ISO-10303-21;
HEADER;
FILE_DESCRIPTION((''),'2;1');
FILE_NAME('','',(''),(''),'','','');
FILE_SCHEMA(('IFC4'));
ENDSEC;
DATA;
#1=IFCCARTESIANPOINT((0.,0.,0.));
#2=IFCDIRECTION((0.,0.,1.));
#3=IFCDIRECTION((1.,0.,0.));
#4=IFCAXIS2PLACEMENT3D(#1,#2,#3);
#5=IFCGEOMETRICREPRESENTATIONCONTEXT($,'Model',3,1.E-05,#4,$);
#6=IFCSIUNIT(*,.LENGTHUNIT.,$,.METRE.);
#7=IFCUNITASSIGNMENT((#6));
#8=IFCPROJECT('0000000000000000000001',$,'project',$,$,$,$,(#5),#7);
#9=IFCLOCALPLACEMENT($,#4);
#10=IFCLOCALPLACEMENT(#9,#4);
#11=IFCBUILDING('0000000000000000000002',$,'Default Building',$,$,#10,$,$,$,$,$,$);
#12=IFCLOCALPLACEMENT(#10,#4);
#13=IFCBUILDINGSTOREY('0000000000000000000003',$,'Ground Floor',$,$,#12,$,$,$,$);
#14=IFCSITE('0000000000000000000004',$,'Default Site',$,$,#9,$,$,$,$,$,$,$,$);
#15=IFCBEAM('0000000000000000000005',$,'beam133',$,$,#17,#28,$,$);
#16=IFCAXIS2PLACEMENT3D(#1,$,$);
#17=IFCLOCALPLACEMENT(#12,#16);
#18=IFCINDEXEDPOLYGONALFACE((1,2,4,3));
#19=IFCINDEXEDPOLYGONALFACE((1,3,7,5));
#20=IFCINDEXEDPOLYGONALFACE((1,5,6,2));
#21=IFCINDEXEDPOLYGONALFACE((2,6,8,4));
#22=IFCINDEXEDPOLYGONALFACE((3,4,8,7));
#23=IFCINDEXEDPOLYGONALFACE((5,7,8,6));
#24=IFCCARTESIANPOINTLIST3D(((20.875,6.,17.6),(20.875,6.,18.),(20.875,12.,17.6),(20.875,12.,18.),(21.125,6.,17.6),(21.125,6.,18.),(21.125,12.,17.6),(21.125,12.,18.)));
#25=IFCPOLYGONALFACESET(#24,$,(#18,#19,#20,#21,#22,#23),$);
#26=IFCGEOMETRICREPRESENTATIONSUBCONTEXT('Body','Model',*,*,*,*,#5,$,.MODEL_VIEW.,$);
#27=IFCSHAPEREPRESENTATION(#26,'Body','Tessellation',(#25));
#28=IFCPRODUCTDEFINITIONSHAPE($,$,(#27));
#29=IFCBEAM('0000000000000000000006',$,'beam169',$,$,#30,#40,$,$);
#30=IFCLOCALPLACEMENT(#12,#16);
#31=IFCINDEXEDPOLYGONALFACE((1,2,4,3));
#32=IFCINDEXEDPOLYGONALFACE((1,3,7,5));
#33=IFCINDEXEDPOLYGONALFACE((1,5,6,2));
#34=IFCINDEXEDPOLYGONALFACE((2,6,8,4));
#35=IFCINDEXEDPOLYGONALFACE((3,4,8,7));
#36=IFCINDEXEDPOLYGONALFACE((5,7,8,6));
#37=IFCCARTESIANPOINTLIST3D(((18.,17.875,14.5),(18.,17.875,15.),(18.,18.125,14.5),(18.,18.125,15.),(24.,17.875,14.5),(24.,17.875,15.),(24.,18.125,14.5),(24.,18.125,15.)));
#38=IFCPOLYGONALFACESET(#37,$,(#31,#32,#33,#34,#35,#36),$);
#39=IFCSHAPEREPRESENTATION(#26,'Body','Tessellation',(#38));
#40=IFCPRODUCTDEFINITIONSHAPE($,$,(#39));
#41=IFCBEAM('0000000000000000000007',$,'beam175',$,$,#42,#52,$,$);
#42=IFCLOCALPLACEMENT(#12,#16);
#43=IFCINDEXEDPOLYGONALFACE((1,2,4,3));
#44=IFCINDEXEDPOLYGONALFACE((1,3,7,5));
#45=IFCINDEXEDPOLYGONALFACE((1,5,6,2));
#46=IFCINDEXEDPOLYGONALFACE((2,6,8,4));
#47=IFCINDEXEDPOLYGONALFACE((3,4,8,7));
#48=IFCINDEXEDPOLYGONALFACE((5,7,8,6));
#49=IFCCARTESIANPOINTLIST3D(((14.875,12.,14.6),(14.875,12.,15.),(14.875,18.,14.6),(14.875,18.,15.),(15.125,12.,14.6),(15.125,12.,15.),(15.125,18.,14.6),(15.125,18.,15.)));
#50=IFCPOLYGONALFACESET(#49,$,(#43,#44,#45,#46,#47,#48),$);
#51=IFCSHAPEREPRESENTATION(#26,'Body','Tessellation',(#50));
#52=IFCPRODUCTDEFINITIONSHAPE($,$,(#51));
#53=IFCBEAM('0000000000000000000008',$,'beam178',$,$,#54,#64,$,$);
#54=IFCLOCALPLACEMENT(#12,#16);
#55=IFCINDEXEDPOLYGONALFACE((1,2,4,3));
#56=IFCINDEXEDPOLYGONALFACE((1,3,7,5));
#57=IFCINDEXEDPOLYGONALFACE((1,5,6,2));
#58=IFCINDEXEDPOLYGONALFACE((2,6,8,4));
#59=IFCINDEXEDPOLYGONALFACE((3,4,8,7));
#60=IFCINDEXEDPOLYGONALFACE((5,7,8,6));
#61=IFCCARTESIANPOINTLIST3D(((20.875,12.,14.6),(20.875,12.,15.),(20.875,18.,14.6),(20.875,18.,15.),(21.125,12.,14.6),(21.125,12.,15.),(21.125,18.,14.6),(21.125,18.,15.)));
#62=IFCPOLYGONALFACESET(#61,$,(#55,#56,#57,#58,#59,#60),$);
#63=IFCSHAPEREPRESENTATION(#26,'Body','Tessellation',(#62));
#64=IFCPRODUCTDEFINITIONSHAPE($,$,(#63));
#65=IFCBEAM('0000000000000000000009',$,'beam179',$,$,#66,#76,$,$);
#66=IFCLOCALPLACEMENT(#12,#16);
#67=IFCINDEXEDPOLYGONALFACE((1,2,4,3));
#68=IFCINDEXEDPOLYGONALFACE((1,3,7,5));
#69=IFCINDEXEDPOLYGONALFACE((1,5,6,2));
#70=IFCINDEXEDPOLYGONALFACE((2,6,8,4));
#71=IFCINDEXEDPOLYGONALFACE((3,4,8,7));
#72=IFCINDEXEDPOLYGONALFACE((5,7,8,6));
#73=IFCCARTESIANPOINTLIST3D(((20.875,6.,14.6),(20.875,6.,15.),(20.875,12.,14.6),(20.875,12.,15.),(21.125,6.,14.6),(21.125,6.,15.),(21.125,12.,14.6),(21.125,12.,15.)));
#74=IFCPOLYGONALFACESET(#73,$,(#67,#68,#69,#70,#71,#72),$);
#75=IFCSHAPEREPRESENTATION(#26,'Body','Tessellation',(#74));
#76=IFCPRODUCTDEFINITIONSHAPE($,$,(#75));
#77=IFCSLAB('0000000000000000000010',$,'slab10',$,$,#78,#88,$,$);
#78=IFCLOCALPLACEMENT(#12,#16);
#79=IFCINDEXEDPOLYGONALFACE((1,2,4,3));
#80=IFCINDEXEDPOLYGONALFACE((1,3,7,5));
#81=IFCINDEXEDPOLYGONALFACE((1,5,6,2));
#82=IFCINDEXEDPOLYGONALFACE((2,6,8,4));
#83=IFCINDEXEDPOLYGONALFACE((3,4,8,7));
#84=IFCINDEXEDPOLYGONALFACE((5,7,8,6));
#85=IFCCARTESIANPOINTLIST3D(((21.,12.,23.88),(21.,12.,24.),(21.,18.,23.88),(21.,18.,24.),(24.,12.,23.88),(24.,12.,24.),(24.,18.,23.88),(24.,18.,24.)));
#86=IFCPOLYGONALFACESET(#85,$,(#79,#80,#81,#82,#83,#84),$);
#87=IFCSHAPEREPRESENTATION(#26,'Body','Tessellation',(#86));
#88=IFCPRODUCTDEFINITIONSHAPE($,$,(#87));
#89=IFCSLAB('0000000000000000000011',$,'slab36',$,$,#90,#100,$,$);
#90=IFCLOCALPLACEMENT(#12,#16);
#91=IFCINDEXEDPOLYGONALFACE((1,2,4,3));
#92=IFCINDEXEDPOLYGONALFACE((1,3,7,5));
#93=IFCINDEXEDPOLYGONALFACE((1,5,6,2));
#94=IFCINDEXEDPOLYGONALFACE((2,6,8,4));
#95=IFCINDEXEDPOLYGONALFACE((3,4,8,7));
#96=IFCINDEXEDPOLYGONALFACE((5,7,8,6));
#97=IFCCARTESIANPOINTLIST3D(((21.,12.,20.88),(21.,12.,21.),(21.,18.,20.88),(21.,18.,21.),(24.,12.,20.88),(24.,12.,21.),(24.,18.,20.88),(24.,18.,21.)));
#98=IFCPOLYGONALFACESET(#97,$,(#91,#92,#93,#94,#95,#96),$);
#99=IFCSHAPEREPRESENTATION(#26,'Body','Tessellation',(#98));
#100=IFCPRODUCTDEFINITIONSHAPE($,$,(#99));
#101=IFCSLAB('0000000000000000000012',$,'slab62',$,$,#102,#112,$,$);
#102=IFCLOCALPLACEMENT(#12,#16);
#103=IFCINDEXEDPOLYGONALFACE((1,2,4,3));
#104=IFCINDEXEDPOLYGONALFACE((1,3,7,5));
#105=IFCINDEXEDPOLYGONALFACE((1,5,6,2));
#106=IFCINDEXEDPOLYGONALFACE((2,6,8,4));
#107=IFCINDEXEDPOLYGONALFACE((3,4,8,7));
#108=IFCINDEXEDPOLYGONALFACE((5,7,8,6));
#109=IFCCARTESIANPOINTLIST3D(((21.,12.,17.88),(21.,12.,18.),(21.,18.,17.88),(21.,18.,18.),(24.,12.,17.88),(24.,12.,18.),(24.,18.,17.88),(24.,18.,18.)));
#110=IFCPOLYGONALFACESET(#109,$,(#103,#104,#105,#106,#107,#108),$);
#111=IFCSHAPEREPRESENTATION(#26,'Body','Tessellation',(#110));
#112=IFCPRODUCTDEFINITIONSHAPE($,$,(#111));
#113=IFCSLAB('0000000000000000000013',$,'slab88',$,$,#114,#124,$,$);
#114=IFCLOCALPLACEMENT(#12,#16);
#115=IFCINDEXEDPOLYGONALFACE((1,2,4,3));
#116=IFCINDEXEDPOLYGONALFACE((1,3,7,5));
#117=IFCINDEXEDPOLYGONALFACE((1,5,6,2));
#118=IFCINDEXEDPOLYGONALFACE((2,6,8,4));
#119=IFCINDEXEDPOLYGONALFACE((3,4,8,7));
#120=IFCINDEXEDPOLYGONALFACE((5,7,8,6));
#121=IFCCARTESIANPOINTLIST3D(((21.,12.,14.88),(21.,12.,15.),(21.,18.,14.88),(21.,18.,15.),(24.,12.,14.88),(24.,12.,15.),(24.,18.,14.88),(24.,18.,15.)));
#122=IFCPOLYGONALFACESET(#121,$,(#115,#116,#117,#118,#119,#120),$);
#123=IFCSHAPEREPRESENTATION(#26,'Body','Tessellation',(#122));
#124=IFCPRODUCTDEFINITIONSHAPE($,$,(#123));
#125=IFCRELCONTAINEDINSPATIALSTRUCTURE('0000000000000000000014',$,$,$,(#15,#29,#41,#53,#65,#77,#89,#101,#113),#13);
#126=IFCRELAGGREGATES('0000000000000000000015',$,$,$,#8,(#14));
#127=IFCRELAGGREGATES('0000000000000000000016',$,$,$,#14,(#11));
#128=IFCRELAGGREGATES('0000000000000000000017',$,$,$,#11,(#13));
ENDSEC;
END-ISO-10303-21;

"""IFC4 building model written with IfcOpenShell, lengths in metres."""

from ifc_helpers import new_model, si_unit, frame, origin_with_axes, place, context, subcontext, project, spatial, indexed_curve, outline, extrude, element, save


model = new_model("IFC4")

# Units and contexts
model_context = context("Model", 3, precision=1e-05, world=origin_with_axes())
body_context = subcontext(model_context, "Body", "Model", "MODEL_VIEW")
ifc_project = project(units=[si_unit("LENGTHUNIT", "METRE")], contexts=[model_context])

# Site, building, storey
site_placement = place(None, origin_with_axes())
site = spatial("IfcSite", under=ifc_project, at=site_placement, Name="Default Site")
building_placement = place(site_placement, origin_with_axes())
building = spatial("IfcBuilding", under=site, at=building_placement, Name="Default Building")
storey_placement = place(building_placement, origin_with_axes())
storey = spatial("IfcBuildingStorey", under=building, at=storey_placement, Name="Ground Floor")

# Beams
for number, where, z_axis, x_axis, name in (
    (1, (20.875, 12.0, 17.6), (0.0, 0.0, 1.0), (0.0, -1.0, 0.0), "beam133"),
):
    element("IfcBeam", number, at=place(storey_placement, frame(where, z_axis=z_axis, x_axis=x_axis)), inside=storey, Name=name, context=body_context, shape_type="SweptSolid", body=[
        extrude(outline(indexed_curve([(0.0, 0.0), (0.0, 0.25), (6.0, 0.25), (6.0, 0.0), (0.0, 0.0)], self_intersect=False)), origin_with_axes(), (0.0, 0.0, 1.0), 0.4),
    ])
beam_placement = place(storey_placement, frame((18.0, 17.875, 14.5), z_axis=(0.0, 0.0, 1.0), x_axis=(1.0, 0.0, 0.0)))
element("IfcBeam", 2, at=beam_placement, inside=storey, Name="beam169", context=body_context, shape_type="SweptSolid", body=[
    extrude(outline(indexed_curve([(0.0, 0.0), (0.0, 0.25), (6.0, 0.25), (6.0, 0.0), (0.0, 0.0)], self_intersect=False)), origin_with_axes(), (0.0, 0.0, 1.0), 0.5),
])
for number, where, z_axis, x_axis, name in (
    (3, (14.875, 18.0, 14.6), (0.0, 0.0, 1.0), (0.0, -1.0, 0.0), "beam175"),
    (4, (20.875, 18.0, 14.6), (0.0, 0.0, 1.0), (0.0, -1.0, 0.0), "beam178"),
    (5, (20.875, 12.0, 14.6), (0.0, 0.0, 1.0), (0.0, -1.0, 0.0), "beam179"),
):
    element("IfcBeam", number, at=place(storey_placement, frame(where, z_axis=z_axis, x_axis=x_axis)), inside=storey, Name=name, context=body_context, shape_type="SweptSolid", body=[
        extrude(outline(indexed_curve([(0.0, 0.0), (0.0, 0.25), (6.0, 0.25), (6.0, 0.0), (0.0, 0.0)], self_intersect=False)), origin_with_axes(), (0.0, 0.0, 1.0), 0.4),
    ])

# Slabs
for number, where, z_axis, x_axis, name in (
    (6, (21.0, 12.0, 23.88), (0.0, 0.0, 1.0), (1.0, 0.0, 0.0), "slab10"),
    (7, (21.0, 12.0, 20.88), (0.0, 0.0, 1.0), (1.0, 0.0, 0.0), "slab36"),
    (8, (21.0, 12.0, 17.88), (0.0, 0.0, 1.0), (1.0, 0.0, 0.0), "slab62"),
    (9, (21.0, 12.0, 14.88), (0.0, 0.0, 1.0), (1.0, 0.0, 0.0), "slab88"),
):
    element("IfcSlab", number, at=place(storey_placement, frame(where, z_axis=z_axis, x_axis=x_axis)), inside=storey, Name=name, context=body_context, shape_type="SweptSolid", body=[
        extrude(outline(indexed_curve([(0.0, 0.0), (0.0, 6.0), (3.0, 6.0), (3.0, 0.0), (0.0, 0.0)], self_intersect=False)), origin_with_axes(), (0.0, 0.0, 1.0), 0.12),
    ])

save(model, "model.ifc")
